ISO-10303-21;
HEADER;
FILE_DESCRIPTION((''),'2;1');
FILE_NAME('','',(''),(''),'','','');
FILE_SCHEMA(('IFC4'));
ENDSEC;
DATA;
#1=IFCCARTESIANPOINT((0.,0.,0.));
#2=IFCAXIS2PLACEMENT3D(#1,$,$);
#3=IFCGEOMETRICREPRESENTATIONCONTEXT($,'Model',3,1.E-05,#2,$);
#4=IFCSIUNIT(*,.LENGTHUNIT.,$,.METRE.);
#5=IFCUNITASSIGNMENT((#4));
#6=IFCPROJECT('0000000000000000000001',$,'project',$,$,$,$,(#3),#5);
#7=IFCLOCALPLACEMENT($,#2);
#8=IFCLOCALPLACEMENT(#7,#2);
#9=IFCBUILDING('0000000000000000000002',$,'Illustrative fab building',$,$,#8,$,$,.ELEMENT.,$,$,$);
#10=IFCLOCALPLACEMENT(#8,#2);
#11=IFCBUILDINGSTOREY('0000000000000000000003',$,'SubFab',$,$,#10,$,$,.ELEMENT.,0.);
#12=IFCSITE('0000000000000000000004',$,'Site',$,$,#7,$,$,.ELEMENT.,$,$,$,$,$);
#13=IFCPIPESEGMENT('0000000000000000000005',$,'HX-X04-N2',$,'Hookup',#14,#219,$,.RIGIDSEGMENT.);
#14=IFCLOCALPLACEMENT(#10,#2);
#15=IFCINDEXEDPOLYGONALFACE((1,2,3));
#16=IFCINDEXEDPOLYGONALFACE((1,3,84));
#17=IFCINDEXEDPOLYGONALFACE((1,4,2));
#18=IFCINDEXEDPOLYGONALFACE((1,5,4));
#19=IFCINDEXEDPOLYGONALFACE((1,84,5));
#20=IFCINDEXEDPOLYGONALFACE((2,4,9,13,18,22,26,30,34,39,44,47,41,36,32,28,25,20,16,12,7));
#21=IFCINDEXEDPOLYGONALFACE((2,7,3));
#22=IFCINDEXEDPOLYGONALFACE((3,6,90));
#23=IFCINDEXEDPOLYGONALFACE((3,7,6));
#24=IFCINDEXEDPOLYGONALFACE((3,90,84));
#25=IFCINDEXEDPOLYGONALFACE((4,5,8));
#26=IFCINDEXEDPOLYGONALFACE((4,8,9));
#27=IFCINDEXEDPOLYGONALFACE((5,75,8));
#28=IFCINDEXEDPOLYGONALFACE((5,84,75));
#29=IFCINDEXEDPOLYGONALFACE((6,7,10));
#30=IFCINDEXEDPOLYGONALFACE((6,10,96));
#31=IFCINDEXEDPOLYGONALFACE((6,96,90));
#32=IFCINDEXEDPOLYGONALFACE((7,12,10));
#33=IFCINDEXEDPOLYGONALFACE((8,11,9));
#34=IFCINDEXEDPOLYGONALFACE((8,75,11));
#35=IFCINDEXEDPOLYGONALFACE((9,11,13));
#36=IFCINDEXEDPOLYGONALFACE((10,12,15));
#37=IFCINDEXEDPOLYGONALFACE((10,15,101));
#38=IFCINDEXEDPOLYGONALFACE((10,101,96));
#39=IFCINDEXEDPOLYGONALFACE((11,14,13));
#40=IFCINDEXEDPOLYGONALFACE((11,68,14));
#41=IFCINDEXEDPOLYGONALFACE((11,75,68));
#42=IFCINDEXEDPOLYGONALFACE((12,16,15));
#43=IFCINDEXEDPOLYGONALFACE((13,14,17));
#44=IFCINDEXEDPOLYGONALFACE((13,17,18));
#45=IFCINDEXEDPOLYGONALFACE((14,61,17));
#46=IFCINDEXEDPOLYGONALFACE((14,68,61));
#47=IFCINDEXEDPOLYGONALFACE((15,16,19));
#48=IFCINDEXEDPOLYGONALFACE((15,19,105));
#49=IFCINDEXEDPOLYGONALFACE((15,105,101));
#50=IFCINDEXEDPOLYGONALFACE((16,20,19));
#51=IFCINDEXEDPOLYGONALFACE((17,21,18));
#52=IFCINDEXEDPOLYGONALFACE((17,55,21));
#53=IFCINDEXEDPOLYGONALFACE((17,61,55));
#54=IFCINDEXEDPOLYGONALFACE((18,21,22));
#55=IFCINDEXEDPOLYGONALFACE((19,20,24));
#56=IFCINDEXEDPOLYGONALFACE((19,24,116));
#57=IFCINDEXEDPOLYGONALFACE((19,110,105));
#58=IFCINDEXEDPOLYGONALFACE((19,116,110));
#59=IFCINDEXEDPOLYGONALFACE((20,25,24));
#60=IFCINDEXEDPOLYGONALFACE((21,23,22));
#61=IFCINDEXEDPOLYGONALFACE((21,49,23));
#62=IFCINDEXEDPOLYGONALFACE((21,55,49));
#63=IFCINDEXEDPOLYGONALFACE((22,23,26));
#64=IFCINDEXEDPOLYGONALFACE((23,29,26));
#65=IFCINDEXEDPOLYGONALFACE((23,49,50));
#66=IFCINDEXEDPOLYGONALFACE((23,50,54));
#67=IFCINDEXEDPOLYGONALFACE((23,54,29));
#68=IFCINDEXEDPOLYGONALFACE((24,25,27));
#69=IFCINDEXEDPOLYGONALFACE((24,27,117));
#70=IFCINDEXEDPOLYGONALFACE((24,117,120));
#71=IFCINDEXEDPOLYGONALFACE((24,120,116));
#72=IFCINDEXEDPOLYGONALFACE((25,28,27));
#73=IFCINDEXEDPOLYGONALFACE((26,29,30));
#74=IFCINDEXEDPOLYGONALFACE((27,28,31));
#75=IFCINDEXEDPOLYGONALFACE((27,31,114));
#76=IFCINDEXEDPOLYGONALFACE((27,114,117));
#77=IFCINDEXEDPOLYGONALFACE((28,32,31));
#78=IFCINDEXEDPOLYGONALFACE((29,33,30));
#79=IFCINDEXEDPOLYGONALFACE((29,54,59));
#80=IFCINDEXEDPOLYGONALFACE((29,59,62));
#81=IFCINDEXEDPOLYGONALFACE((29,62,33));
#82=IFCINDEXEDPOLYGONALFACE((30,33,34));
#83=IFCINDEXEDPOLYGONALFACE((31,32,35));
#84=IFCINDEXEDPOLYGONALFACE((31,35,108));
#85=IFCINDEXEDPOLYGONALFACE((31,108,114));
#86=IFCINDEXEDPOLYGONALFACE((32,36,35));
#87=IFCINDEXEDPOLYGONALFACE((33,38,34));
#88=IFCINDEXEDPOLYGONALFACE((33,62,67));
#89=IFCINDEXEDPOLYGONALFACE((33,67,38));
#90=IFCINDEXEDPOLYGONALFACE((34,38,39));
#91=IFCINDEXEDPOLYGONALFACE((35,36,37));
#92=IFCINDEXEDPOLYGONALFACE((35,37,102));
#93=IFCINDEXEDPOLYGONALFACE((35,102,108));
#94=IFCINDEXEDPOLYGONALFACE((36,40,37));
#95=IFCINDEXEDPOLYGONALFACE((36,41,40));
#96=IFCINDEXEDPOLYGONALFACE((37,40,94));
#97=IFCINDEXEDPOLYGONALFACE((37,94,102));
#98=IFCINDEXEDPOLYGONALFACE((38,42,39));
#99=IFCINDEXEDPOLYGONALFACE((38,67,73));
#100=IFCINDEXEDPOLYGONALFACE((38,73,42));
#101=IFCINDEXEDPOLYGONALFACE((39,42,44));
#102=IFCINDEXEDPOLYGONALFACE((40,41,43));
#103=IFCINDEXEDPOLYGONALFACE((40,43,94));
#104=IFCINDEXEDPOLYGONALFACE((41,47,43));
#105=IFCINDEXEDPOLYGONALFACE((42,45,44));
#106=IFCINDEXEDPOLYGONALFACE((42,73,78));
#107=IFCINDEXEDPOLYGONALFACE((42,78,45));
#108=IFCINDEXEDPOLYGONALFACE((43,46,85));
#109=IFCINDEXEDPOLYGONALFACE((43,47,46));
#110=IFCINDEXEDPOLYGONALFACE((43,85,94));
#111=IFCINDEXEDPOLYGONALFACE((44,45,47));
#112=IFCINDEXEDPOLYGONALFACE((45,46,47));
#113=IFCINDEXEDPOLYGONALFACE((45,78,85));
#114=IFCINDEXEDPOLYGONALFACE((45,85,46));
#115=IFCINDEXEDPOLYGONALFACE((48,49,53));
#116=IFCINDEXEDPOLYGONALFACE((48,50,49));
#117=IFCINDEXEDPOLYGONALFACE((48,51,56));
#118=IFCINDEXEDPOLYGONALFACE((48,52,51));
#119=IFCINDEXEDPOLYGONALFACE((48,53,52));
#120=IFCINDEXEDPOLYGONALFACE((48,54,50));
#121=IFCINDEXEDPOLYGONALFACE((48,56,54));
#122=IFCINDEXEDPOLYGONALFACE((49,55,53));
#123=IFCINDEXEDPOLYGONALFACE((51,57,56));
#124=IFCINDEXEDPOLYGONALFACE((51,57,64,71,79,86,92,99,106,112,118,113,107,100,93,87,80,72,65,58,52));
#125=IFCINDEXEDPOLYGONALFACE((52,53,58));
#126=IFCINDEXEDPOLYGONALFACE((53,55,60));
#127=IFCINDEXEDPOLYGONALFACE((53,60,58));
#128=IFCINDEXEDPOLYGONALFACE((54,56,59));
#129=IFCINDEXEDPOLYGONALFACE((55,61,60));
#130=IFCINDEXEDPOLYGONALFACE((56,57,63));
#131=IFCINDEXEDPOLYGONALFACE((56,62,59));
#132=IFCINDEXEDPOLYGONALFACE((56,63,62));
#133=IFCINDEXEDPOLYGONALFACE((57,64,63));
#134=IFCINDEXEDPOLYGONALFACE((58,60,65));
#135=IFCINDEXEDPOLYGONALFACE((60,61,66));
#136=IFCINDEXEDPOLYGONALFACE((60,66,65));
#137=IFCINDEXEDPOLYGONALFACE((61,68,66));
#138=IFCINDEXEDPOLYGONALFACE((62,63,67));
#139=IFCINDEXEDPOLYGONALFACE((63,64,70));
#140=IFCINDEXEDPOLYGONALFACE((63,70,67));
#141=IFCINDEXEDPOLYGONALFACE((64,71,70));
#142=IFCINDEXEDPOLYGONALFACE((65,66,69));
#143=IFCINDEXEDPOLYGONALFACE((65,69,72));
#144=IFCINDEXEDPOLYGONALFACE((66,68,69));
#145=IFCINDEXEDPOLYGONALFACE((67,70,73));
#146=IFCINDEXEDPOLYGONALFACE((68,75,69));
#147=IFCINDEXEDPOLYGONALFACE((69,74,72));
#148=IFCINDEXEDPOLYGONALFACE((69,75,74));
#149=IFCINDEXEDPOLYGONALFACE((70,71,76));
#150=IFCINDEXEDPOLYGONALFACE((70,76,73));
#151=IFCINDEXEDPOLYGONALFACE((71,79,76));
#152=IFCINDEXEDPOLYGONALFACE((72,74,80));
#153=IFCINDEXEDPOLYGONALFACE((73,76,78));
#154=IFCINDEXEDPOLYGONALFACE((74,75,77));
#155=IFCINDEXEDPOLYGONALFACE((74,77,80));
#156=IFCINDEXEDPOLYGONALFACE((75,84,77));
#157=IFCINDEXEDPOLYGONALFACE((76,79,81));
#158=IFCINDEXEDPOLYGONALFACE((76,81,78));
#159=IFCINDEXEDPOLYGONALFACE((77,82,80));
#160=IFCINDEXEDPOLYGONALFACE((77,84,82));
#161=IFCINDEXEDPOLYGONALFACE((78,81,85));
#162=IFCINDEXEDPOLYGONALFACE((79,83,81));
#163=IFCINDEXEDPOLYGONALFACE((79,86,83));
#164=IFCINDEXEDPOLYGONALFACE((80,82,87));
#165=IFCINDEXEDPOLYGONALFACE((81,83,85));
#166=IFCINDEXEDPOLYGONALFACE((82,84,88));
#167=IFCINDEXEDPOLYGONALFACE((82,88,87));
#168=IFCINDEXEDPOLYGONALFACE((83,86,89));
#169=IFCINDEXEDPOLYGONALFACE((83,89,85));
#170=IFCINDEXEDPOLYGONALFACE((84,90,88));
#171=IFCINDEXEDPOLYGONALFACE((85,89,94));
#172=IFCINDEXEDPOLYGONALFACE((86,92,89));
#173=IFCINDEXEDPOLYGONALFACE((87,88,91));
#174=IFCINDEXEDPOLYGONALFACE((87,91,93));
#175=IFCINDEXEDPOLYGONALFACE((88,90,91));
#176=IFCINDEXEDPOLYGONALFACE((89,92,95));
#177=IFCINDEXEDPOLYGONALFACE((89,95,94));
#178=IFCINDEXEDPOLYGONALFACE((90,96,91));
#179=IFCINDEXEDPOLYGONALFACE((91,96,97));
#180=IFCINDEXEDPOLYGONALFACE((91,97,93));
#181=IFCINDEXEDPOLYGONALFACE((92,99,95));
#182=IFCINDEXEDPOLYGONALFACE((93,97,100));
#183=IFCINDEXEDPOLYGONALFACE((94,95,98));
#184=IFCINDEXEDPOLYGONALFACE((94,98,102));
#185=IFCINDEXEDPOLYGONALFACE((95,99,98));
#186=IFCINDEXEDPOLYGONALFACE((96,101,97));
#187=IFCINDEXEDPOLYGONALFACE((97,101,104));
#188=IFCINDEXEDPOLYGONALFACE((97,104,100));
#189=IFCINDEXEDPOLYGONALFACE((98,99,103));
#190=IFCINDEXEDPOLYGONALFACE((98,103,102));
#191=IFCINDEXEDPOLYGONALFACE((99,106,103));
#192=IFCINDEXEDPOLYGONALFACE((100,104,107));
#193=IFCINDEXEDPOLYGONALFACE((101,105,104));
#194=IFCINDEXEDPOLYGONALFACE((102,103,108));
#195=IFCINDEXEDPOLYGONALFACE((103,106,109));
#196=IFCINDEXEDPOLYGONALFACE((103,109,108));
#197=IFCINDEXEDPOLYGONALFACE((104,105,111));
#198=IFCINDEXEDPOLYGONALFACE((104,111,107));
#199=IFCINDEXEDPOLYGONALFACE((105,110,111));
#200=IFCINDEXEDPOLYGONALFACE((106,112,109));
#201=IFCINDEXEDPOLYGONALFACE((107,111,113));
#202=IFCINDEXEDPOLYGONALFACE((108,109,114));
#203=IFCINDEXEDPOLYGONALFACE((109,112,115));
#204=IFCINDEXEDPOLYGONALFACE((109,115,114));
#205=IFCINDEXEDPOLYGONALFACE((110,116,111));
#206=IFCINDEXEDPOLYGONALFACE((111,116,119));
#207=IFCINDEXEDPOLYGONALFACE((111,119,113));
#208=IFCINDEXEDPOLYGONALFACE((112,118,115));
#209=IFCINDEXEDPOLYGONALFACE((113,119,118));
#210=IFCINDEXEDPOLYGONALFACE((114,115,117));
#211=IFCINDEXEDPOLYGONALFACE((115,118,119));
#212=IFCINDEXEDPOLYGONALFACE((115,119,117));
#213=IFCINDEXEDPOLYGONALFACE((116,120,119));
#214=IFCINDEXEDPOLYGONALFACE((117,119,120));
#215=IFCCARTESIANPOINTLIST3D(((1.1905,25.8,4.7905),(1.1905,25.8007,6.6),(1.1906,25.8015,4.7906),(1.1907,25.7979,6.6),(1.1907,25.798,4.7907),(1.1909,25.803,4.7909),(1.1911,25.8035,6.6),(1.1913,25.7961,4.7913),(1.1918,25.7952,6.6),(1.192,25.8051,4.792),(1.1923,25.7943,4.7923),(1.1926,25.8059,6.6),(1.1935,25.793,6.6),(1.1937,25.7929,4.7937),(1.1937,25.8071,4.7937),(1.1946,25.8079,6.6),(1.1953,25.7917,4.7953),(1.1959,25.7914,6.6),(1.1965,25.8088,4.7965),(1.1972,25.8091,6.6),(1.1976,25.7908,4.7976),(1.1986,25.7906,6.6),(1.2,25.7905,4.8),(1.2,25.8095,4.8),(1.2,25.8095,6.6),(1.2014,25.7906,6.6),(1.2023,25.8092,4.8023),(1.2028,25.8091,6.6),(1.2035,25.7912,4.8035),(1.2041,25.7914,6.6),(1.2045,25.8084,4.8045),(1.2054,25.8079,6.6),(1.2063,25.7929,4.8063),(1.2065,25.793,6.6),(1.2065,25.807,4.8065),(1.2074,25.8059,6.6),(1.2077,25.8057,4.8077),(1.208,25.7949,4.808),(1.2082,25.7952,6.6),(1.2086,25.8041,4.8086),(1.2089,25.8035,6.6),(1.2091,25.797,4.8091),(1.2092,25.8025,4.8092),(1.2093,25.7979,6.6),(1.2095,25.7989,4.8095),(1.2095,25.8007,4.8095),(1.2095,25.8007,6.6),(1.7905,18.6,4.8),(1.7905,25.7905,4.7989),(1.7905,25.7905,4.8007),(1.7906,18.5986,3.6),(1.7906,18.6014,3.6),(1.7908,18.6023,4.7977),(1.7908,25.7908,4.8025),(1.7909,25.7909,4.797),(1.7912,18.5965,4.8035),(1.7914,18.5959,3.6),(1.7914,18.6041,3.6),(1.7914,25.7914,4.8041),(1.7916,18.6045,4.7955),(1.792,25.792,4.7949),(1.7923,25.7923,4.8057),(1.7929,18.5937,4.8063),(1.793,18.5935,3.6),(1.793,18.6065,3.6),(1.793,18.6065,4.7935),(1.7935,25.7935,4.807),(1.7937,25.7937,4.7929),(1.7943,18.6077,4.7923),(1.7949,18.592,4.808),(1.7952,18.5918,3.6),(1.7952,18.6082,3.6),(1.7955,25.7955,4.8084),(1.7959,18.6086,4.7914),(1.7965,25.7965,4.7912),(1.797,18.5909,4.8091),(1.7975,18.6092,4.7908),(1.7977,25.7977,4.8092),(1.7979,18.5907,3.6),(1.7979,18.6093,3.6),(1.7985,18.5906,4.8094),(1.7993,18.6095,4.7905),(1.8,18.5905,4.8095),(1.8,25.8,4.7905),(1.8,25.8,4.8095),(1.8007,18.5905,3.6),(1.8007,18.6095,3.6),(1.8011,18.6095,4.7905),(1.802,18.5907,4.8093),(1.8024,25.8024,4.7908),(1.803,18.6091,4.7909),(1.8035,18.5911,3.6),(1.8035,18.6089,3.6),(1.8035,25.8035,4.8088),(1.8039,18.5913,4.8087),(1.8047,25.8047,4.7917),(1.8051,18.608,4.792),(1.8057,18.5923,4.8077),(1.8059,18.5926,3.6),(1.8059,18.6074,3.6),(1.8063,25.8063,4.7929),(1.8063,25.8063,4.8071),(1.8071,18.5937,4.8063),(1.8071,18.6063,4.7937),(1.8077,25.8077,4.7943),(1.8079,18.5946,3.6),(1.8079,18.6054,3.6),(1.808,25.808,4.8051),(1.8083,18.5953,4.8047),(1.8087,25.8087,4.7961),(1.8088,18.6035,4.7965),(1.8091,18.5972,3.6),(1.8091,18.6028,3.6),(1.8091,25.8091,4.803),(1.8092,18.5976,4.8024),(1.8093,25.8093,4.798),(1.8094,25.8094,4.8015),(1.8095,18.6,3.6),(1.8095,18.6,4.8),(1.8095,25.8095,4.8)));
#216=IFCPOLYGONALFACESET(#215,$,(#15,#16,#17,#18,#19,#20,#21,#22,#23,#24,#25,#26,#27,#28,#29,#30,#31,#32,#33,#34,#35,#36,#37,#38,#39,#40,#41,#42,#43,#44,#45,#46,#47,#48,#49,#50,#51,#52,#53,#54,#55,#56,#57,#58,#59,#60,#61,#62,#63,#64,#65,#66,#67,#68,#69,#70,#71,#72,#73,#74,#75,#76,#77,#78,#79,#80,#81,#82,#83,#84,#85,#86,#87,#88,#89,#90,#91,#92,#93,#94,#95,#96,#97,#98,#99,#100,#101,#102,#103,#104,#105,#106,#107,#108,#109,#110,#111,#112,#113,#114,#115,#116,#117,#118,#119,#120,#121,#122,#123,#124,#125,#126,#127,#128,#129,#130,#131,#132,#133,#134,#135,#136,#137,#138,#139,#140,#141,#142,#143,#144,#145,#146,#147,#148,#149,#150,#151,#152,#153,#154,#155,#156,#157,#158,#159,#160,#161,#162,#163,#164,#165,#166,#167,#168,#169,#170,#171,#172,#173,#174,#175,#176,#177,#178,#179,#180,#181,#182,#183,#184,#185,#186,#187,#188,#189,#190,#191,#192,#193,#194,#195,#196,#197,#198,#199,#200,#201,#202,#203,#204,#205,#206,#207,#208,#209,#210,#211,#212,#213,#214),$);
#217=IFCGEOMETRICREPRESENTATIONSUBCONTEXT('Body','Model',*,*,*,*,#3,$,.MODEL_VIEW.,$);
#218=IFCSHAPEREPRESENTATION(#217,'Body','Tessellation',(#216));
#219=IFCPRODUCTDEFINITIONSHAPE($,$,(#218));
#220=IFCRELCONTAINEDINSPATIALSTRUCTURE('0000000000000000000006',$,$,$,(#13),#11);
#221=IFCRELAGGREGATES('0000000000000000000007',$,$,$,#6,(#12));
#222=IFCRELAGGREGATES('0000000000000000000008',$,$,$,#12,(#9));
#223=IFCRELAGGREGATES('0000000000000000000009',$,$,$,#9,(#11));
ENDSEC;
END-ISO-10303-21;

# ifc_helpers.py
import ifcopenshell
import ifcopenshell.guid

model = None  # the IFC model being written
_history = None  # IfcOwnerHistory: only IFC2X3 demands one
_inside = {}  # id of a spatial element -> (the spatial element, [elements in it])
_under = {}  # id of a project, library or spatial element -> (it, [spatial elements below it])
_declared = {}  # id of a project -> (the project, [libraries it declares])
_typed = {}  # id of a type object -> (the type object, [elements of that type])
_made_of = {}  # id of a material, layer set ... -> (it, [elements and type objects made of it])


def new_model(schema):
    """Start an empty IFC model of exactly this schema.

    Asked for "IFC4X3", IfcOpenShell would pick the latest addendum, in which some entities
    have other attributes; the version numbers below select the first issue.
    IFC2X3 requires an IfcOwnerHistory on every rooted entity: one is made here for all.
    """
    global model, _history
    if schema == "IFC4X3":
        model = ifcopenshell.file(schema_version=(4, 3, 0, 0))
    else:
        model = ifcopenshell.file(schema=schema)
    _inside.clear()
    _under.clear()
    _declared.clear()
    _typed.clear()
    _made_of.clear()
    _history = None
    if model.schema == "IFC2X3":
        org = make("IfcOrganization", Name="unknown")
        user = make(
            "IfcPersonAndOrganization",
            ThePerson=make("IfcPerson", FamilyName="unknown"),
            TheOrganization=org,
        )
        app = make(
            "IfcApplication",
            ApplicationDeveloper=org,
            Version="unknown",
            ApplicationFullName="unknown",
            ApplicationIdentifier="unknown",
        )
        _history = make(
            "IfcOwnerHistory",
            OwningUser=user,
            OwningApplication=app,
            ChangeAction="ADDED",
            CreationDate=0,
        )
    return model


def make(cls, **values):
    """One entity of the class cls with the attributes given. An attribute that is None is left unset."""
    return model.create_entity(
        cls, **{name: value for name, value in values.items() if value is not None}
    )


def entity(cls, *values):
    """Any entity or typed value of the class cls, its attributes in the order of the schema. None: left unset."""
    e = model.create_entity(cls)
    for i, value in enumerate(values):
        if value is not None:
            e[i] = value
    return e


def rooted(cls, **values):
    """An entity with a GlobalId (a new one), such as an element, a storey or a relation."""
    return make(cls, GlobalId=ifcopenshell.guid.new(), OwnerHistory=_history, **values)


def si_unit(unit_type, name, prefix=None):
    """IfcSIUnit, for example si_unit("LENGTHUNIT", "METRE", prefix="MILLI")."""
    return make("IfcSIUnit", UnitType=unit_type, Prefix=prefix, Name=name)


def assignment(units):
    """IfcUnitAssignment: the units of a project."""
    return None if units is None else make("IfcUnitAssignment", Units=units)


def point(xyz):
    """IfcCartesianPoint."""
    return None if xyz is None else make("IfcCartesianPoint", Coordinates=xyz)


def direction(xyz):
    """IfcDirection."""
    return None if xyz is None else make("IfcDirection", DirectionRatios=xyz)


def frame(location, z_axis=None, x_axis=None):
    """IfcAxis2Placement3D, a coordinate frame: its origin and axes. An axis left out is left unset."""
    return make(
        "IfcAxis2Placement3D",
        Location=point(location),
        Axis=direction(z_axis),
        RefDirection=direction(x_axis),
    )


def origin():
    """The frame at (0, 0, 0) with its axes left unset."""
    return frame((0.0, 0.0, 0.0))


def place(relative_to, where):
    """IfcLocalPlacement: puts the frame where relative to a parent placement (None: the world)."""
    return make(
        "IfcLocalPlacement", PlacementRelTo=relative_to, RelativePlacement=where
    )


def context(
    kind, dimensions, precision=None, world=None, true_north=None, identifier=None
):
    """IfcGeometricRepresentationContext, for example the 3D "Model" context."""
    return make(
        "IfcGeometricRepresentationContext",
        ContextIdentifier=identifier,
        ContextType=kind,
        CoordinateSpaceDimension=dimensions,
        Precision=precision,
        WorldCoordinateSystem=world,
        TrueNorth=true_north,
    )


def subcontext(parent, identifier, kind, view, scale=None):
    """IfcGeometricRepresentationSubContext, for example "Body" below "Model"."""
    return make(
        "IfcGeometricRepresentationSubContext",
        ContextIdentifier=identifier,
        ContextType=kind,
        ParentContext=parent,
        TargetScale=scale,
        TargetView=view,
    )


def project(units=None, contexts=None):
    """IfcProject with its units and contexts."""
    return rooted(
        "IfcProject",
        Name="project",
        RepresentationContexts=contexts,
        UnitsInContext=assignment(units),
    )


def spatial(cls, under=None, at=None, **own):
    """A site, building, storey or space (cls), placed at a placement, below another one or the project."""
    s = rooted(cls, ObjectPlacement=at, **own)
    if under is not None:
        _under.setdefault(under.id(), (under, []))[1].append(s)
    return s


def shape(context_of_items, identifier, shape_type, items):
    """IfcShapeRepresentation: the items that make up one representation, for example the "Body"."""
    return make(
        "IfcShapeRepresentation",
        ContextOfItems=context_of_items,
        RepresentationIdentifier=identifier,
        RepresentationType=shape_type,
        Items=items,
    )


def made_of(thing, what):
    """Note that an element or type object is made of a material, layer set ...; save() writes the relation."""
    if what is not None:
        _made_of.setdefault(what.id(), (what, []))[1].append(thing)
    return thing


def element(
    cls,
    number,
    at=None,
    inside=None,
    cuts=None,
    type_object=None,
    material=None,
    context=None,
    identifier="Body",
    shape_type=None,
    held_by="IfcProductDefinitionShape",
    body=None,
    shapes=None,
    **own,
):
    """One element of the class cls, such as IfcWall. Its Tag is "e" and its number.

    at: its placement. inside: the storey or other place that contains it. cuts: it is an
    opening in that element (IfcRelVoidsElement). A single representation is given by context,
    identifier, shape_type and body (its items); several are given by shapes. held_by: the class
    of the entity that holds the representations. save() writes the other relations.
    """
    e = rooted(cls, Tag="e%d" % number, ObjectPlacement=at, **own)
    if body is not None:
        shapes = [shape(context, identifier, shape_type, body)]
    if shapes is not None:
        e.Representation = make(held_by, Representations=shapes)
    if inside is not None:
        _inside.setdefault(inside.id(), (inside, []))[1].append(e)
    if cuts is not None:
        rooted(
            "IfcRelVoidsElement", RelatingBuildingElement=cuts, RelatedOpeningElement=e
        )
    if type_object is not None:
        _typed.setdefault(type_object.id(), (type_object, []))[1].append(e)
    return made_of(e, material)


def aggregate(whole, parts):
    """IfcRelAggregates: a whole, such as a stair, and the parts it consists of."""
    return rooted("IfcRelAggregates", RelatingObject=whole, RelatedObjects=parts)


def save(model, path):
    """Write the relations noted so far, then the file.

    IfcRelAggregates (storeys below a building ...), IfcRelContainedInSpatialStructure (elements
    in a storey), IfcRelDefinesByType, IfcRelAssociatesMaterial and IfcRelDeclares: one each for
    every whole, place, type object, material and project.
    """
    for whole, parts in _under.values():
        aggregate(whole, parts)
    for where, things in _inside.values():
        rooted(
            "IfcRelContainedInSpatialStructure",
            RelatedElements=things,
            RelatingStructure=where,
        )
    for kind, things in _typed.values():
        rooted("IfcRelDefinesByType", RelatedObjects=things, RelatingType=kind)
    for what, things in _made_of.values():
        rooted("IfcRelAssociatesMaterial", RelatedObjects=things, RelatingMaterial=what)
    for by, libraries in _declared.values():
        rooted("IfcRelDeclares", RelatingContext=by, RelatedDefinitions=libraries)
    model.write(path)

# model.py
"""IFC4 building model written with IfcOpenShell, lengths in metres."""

from ifc_helpers import new_model, entity, si_unit, origin, place, context, subcontext, project, spatial, element, save


model = new_model("IFC4")

# Units and contexts
model_context = context("Model", 3, precision=1e-05, world=origin())
body_context = subcontext(model_context, "Body", "Model", "MODEL_VIEW")
ifc_project = project(units=[si_unit("LENGTHUNIT", "METRE")], contexts=[model_context])

# Site, building, storey
site_placement = place(None, origin())
site = spatial("IfcSite", under=ifc_project, at=site_placement, Name="Site", CompositionType="ELEMENT")
building_placement = place(site_placement, origin())
building = spatial("IfcBuilding", under=site, at=building_placement, Name="Illustrative fab building", CompositionType="ELEMENT")
storey_placement = place(building_placement, origin())
storey = spatial("IfcBuildingStorey", under=building, at=storey_placement, Name="SubFab", CompositionType="ELEMENT", Elevation=0.0)

# Pipe segment
pipe_segment_1_placement = place(storey_placement, origin())
element("IfcPipeSegment", 1, at=pipe_segment_1_placement, inside=storey, Name="HX-X04-N2", ObjectType="Hookup", PredefinedType="RIGIDSEGMENT", context=body_context, shape_type="AdvancedSweptSolid", body=[
    entity("IfcSweptDiskSolid", entity("IfcPolyline", [entity("IfcCartesianPoint", [1.8, 18.6, 3.6]), entity("IfcCartesianPoint", [1.8, 18.6, 4.8]), entity("IfcCartesianPoint", [1.8, 25.8, 4.8]), entity("IfcCartesianPoint", [1.2, 25.8, 4.8]), entity("IfcCartesianPoint", [1.2, 25.8, 6.6])]), 0.0095),
])

save(model, "model.ifc")
